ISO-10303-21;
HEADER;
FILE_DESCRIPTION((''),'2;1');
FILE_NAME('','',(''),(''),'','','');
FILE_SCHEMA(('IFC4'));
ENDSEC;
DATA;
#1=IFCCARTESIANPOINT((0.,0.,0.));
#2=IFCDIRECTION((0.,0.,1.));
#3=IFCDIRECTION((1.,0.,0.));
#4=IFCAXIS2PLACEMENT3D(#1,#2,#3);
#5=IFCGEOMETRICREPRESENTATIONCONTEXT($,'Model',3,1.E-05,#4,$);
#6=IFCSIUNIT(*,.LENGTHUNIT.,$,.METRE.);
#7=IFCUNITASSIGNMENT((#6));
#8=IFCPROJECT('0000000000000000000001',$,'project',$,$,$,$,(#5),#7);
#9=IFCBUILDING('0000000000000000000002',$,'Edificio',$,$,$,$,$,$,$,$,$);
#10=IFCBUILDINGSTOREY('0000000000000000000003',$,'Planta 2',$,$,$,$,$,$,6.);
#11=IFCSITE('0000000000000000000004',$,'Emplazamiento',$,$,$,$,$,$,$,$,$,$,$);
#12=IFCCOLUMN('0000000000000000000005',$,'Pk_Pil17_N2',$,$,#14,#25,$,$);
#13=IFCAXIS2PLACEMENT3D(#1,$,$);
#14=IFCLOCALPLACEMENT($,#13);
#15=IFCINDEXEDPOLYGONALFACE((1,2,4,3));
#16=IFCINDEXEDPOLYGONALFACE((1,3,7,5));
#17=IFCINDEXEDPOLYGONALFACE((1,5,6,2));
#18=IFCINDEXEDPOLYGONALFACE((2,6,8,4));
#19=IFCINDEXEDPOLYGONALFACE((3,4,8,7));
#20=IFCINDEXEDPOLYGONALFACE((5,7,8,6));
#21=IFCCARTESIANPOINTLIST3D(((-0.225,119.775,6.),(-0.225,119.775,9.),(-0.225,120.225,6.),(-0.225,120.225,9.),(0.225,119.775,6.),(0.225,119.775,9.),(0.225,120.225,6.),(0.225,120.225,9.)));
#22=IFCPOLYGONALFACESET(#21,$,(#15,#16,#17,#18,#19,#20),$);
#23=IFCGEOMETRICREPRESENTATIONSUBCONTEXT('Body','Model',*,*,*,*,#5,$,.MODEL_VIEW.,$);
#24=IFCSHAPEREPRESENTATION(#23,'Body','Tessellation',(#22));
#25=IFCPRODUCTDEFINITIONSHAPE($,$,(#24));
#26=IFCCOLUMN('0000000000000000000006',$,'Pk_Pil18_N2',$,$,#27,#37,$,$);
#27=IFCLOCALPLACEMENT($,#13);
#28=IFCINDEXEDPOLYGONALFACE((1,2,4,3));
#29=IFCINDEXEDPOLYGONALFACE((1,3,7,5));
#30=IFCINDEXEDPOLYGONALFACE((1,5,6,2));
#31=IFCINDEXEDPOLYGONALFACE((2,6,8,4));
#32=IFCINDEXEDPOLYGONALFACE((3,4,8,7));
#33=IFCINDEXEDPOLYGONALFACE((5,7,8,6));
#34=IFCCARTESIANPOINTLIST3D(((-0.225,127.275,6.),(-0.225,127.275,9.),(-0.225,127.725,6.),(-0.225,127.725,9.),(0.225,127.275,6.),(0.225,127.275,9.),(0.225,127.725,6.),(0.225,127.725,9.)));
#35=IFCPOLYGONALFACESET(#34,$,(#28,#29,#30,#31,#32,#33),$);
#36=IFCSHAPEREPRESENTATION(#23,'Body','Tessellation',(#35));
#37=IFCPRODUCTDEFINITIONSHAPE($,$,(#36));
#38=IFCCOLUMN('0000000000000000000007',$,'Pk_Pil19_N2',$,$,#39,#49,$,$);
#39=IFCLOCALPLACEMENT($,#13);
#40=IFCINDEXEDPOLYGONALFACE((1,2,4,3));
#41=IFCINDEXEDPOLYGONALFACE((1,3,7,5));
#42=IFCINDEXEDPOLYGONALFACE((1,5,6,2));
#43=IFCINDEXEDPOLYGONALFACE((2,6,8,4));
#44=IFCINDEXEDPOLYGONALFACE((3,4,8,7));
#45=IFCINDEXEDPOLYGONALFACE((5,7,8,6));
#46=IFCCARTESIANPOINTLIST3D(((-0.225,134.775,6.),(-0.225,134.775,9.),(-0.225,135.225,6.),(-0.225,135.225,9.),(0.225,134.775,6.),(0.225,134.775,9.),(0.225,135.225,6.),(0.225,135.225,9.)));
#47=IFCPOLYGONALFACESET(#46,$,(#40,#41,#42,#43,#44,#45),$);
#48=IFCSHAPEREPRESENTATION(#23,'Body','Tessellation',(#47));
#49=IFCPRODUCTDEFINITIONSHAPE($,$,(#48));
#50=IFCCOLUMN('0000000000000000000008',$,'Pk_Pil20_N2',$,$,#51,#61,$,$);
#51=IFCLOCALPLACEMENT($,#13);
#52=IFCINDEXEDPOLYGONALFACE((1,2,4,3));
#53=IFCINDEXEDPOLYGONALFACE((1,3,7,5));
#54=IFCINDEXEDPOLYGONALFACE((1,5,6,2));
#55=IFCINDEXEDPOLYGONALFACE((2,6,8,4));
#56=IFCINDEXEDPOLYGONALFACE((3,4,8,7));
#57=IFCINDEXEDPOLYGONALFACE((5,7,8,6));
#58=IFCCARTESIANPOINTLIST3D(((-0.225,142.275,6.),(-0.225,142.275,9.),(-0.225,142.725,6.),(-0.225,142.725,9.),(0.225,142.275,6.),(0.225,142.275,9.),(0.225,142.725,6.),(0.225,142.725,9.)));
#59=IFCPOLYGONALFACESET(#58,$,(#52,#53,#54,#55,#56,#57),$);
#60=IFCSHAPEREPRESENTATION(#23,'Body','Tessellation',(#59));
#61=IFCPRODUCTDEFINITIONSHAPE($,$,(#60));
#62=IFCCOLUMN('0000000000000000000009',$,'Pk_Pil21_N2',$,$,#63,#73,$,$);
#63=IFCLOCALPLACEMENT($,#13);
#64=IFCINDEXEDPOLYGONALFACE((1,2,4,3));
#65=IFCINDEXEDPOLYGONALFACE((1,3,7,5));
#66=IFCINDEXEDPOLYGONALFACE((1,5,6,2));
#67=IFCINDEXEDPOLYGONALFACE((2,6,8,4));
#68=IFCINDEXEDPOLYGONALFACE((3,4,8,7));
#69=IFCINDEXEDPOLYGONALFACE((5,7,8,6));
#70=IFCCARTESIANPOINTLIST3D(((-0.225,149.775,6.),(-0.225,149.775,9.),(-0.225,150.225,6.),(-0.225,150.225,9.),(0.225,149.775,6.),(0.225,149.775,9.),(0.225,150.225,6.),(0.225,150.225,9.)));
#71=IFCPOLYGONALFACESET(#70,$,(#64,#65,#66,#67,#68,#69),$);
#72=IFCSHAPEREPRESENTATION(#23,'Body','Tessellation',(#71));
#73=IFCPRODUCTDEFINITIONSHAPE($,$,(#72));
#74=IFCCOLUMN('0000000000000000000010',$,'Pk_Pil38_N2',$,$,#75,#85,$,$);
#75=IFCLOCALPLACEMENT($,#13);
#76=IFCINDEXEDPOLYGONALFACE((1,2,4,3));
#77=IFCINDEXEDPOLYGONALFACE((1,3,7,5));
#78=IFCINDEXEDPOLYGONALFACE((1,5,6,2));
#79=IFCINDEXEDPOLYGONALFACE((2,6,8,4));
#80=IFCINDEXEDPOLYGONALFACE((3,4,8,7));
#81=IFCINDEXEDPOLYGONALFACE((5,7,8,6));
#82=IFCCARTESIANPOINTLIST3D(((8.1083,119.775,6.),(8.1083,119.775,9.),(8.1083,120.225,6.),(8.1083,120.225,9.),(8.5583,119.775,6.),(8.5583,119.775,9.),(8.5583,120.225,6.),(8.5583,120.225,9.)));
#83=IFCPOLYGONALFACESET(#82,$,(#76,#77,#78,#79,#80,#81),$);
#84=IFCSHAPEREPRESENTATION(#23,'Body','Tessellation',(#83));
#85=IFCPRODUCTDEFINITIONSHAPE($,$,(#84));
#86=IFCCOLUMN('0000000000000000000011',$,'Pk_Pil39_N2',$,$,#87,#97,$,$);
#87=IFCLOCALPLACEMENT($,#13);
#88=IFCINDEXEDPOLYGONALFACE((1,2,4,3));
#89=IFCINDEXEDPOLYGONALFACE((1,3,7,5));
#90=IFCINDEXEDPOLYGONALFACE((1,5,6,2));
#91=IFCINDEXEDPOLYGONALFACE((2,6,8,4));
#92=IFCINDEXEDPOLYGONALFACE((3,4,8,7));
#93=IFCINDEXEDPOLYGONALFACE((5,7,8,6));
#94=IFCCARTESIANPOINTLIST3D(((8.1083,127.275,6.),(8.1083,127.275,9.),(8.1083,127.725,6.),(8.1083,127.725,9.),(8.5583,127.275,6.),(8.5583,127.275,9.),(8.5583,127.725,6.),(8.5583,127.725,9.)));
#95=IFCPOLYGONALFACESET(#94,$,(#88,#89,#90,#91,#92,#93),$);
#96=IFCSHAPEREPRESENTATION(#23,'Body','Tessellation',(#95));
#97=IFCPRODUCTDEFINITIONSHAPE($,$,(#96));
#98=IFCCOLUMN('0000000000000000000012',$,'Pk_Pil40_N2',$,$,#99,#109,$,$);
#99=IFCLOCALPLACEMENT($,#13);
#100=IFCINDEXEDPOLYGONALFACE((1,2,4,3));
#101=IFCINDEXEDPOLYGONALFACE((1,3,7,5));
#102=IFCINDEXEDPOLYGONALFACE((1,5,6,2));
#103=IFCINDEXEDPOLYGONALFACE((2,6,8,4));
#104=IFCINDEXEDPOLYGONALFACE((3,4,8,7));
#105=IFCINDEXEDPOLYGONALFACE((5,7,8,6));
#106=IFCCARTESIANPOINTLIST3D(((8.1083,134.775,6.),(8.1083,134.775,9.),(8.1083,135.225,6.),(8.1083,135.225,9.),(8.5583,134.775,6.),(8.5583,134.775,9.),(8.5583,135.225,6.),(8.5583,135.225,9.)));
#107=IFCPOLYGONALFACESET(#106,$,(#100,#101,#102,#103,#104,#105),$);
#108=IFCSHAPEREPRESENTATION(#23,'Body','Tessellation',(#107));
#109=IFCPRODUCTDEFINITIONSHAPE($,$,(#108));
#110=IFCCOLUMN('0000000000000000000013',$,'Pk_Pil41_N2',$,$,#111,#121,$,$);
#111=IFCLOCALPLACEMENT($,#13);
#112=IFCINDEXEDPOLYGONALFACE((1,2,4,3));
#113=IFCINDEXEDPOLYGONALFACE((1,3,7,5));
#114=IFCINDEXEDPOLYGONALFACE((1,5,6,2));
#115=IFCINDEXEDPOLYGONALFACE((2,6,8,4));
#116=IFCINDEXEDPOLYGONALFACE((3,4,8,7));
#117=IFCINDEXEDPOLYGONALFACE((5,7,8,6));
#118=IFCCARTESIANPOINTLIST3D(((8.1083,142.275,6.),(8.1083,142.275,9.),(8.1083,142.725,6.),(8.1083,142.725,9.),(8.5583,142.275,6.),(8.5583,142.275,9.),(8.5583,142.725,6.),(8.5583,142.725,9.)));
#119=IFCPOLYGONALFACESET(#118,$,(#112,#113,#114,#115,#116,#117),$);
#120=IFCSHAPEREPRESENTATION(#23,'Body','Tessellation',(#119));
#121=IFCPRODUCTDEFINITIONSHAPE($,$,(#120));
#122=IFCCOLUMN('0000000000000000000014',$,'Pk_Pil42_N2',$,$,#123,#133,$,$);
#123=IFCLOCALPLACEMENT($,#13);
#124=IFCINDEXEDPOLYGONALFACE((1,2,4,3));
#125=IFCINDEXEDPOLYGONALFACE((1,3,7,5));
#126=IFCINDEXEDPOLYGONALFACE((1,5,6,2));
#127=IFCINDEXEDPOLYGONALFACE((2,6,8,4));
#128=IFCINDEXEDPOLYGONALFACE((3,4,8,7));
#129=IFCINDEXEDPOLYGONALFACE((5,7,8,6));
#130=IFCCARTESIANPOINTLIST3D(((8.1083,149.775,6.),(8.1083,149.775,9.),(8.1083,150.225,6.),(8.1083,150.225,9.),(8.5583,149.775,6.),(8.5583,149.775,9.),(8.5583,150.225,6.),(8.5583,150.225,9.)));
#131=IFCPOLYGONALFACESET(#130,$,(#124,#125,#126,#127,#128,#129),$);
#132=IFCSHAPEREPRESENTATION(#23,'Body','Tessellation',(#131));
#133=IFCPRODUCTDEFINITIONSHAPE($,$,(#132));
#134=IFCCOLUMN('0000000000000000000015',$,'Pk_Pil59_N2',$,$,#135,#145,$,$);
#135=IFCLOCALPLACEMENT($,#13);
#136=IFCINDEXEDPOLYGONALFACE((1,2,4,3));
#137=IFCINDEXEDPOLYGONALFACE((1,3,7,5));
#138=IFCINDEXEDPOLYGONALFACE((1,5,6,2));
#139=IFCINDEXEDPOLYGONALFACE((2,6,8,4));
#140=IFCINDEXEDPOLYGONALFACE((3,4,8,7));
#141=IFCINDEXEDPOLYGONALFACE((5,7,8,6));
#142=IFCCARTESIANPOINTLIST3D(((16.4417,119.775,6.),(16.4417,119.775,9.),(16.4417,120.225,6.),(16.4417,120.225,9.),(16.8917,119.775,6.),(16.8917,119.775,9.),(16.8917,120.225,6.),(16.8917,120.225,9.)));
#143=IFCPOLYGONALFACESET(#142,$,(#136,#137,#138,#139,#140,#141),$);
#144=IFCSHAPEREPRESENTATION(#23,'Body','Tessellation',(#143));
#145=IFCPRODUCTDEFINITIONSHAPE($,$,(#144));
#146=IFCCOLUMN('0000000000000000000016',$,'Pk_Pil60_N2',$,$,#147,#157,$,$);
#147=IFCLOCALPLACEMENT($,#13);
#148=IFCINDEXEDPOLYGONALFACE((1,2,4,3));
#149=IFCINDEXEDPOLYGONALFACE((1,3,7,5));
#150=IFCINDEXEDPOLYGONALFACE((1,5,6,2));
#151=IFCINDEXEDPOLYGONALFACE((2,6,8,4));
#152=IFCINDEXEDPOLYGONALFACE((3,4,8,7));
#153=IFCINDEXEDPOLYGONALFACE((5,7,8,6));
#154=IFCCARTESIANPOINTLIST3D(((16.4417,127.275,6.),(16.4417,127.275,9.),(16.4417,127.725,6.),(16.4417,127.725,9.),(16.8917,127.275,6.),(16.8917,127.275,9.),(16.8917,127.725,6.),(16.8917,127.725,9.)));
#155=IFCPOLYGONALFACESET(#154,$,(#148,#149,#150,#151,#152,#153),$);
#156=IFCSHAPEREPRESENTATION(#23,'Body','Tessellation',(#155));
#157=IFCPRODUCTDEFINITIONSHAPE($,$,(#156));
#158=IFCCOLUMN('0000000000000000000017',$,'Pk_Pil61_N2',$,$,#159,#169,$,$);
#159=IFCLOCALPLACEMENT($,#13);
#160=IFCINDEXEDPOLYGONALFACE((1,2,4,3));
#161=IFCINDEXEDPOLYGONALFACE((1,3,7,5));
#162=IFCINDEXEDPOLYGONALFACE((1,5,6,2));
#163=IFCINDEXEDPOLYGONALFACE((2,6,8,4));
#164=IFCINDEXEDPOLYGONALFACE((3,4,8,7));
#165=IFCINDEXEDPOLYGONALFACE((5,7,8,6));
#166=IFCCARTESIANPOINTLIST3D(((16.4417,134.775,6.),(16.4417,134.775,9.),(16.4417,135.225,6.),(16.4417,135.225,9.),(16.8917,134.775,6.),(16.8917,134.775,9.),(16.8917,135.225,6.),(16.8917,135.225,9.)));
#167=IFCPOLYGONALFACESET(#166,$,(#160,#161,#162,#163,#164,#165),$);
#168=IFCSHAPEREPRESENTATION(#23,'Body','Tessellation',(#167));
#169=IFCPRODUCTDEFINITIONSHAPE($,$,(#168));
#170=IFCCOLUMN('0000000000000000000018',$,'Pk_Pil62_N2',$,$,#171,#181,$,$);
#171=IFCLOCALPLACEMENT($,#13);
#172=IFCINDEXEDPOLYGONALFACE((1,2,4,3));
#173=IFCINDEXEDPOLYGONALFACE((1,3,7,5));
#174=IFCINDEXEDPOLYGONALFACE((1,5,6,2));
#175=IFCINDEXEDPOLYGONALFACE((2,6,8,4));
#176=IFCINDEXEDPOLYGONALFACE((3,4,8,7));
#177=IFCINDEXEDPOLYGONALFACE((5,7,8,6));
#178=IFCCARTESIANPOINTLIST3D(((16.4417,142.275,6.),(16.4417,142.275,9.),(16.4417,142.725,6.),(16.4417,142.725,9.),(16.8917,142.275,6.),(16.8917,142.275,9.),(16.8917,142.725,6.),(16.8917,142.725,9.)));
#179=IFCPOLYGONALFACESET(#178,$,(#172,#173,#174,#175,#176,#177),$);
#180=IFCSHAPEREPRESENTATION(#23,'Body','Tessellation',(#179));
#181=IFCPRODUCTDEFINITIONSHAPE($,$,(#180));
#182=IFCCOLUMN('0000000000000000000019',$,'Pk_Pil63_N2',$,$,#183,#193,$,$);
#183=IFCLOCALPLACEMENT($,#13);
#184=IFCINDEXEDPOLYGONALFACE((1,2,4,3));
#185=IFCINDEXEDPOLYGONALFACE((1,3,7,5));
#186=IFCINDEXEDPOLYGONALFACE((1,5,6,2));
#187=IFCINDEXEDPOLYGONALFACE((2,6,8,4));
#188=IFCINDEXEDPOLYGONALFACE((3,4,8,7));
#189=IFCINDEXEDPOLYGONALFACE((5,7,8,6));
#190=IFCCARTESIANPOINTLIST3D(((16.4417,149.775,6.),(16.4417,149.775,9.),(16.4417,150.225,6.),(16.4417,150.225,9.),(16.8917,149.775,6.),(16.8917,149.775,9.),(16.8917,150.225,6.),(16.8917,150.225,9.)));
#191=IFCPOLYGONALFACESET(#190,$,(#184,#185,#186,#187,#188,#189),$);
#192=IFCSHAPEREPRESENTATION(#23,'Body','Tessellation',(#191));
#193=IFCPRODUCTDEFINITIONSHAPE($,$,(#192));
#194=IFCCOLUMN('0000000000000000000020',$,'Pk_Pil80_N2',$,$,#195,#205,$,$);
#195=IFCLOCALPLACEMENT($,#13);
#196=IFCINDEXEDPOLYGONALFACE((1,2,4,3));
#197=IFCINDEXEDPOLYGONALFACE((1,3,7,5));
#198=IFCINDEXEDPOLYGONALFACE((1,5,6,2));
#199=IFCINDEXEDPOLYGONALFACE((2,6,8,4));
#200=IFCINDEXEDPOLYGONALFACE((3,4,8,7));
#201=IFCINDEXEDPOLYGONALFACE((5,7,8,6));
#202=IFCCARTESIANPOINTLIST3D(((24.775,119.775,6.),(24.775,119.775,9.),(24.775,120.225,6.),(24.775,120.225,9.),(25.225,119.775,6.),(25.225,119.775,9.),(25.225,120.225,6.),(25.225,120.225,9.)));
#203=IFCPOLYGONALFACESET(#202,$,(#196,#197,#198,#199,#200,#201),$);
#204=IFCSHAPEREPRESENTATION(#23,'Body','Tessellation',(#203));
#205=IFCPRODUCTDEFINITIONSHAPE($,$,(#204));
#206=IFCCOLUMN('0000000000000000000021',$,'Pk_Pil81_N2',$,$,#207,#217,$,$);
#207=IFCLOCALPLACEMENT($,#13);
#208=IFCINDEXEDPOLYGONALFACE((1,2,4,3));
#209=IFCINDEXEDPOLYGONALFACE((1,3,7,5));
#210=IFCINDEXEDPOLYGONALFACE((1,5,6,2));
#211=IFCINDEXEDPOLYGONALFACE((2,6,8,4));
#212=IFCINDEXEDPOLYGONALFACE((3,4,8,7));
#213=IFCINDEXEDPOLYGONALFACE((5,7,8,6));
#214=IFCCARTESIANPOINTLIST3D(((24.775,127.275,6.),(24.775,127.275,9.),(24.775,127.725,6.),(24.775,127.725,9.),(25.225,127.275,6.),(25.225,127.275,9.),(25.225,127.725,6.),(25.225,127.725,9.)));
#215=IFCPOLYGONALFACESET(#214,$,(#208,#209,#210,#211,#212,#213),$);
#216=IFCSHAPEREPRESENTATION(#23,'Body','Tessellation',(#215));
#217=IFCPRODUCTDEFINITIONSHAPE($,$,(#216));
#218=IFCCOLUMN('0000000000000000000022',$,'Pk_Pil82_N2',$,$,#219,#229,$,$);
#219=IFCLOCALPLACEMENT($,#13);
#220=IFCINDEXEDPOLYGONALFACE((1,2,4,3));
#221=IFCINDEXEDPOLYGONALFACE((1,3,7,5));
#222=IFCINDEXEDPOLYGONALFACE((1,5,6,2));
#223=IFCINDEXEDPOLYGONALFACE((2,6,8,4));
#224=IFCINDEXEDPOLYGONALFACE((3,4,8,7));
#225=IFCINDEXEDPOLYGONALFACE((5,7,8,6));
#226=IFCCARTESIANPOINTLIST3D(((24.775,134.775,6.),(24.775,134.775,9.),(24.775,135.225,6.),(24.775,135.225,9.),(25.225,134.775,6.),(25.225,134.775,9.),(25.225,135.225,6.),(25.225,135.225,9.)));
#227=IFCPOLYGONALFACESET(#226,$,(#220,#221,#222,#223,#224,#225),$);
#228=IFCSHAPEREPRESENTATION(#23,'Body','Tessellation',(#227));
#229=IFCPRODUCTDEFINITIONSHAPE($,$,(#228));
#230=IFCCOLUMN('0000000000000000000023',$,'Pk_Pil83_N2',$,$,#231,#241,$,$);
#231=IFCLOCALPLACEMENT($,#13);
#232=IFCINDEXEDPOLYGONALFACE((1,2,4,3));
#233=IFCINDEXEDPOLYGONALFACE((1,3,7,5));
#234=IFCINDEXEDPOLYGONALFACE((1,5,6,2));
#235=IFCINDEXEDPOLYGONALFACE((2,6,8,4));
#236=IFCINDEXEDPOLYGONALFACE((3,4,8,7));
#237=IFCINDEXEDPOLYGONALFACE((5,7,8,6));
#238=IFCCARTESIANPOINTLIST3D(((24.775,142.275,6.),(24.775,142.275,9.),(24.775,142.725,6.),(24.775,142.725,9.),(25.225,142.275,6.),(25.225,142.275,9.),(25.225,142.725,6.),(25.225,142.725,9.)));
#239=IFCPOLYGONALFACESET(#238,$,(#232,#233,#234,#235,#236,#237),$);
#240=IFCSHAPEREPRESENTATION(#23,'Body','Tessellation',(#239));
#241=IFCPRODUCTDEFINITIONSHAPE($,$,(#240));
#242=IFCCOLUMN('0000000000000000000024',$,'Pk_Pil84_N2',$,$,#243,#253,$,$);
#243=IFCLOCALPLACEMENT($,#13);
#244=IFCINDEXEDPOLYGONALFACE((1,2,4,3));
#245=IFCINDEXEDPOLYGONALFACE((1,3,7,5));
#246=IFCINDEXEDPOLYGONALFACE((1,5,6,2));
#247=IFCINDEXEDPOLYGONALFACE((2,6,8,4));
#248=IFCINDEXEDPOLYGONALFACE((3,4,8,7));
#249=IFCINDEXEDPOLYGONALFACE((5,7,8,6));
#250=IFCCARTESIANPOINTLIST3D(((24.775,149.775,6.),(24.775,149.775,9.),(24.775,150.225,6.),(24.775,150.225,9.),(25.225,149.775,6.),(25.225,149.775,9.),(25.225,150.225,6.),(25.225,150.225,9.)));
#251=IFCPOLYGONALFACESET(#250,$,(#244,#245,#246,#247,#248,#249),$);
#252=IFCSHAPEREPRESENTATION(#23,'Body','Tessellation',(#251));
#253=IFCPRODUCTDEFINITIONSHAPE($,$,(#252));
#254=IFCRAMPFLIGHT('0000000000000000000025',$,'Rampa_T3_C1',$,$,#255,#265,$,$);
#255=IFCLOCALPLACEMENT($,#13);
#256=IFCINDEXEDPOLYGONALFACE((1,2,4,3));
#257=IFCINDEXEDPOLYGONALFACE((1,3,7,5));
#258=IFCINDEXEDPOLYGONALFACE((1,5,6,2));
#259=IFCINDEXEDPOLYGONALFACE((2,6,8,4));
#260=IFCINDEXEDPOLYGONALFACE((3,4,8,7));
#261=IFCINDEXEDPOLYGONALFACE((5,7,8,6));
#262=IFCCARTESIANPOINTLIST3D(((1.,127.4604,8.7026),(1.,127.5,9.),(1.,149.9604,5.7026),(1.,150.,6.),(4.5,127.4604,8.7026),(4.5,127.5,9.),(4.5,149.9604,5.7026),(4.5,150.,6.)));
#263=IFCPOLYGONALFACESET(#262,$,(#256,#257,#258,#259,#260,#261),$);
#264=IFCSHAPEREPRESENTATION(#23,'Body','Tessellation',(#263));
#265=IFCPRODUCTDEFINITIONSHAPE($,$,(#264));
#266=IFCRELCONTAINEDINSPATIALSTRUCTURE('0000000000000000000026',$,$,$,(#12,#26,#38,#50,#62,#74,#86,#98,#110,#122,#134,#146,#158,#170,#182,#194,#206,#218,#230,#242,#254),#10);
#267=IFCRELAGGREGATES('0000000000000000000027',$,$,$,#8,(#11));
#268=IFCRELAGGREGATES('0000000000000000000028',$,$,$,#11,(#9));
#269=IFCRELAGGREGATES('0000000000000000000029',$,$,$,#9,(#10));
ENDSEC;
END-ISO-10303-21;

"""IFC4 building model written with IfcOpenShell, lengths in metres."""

from ifc_helpers import new_model, si_unit, frame, origin_with_axes, origin_2d, place, context, subcontext, project, spatial, rectangle, extrude, element, save


model = new_model("IFC4")

# Units and contexts
model_context = context("Model", 3, precision=1e-05, world=origin_with_axes())
body_context = subcontext(model_context, "Body", "Model", "MODEL_VIEW")
ifc_project = project(units=[si_unit("LENGTHUNIT", "METRE")], contexts=[model_context])

# Site, building, storey
site = spatial("IfcSite", under=ifc_project, Name="Emplazamiento")
building = spatial("IfcBuilding", under=site, Name="Edificio")
storey = spatial("IfcBuildingStorey", under=building, Name="Planta 2", Elevation=6.0)

# Columns
for number, where, z_axis, x_axis, name in (
    (1, (0.0, 120.0, 6.0), (0.0, 0.0, 1.0), (1.0, 0.0, 0.0), "Pk_Pil17_N2"),
    (2, (0.0, 127.5, 6.0), (0.0, 0.0, 1.0), (1.0, 0.0, 0.0), "Pk_Pil18_N2"),
    (3, (0.0, 135.0, 6.0), (0.0, 0.0, 1.0), (1.0, 0.0, 0.0), "Pk_Pil19_N2"),
    (4, (0.0, 142.5, 6.0), (0.0, 0.0, 1.0), (1.0, 0.0, 0.0), "Pk_Pil20_N2"),
    (5, (0.0, 150.0, 6.0), (0.0, 0.0, 1.0), (1.0, 0.0, 0.0), "Pk_Pil21_N2"),
    (6, (8.3333, 120.0, 6.0), (0.0, 0.0, 1.0), (1.0, 0.0, 0.0), "Pk_Pil38_N2"),
    (7, (8.3333, 127.5, 6.0), (0.0, 0.0, 1.0), (1.0, 0.0, 0.0), "Pk_Pil39_N2"),
    (8, (8.3333, 135.0, 6.0), (0.0, 0.0, 1.0), (1.0, 0.0, 0.0), "Pk_Pil40_N2"),
    (9, (8.3333, 142.5, 6.0), (0.0, 0.0, 1.0), (1.0, 0.0, 0.0), "Pk_Pil41_N2"),
    (10, (8.3333, 150.0, 6.0), (0.0, 0.0, 1.0), (1.0, 0.0, 0.0), "Pk_Pil42_N2"),
    (11, (16.6667, 120.0, 6.0), (0.0, 0.0, 1.0), (1.0, 0.0, 0.0), "Pk_Pil59_N2"),
    (12, (16.6667, 127.5, 6.0), (0.0, 0.0, 1.0), (1.0, 0.0, 0.0), "Pk_Pil60_N2"),
    (13, (16.6667, 135.0, 6.0), (0.0, 0.0, 1.0), (1.0, 0.0, 0.0), "Pk_Pil61_N2"),
    (14, (16.6667, 142.5, 6.0), (0.0, 0.0, 1.0), (1.0, 0.0, 0.0), "Pk_Pil62_N2"),
    (15, (16.6667, 150.0, 6.0), (0.0, 0.0, 1.0), (1.0, 0.0, 0.0), "Pk_Pil63_N2"),
    (16, (25.0, 120.0, 6.0), (0.0, 0.0, 1.0), (1.0, 0.0, 0.0), "Pk_Pil80_N2"),
    (17, (25.0, 127.5, 6.0), (0.0, 0.0, 1.0), (1.0, 0.0, 0.0), "Pk_Pil81_N2"),
    (18, (25.0, 135.0, 6.0), (0.0, 0.0, 1.0), (1.0, 0.0, 0.0), "Pk_Pil82_N2"),
    (19, (25.0, 142.5, 6.0), (0.0, 0.0, 1.0), (1.0, 0.0, 0.0), "Pk_Pil83_N2"),
    (20, (25.0, 150.0, 6.0), (0.0, 0.0, 1.0), (1.0, 0.0, 0.0), "Pk_Pil84_N2"),
):
    element("IfcColumn", number, at=place(None, frame(where, z_axis=z_axis, x_axis=x_axis)), inside=storey, Name=name, context=body_context, shape_type="SweptSolid", body=[
        extrude(rectangle(XDim=0.45, YDim=0.45, at=origin_2d()), origin_with_axes(), (0.0, 0.0, 1.0), 3.0),
    ])

# Ramp flight
for number, where, z_axis, x_axis, name in (
    (21, (2.75, 138.7104, 7.2026), (0.0, 0.132164, 0.991228), (0.0, -0.991228, 0.132164), "Rampa_T3_C1"),
):
    element("IfcRampFlight", number, at=place(None, frame(where, z_axis=z_axis, x_axis=x_axis)), inside=storey, Name=name, context=body_context, shape_type="SweptSolid", body=[
        extrude(rectangle(XDim=22.6991, YDim=3.5, at=origin_2d()), origin_with_axes(), (0.0, 0.0, 1.0), 0.3),
    ])

save(model, "model.ifc")
